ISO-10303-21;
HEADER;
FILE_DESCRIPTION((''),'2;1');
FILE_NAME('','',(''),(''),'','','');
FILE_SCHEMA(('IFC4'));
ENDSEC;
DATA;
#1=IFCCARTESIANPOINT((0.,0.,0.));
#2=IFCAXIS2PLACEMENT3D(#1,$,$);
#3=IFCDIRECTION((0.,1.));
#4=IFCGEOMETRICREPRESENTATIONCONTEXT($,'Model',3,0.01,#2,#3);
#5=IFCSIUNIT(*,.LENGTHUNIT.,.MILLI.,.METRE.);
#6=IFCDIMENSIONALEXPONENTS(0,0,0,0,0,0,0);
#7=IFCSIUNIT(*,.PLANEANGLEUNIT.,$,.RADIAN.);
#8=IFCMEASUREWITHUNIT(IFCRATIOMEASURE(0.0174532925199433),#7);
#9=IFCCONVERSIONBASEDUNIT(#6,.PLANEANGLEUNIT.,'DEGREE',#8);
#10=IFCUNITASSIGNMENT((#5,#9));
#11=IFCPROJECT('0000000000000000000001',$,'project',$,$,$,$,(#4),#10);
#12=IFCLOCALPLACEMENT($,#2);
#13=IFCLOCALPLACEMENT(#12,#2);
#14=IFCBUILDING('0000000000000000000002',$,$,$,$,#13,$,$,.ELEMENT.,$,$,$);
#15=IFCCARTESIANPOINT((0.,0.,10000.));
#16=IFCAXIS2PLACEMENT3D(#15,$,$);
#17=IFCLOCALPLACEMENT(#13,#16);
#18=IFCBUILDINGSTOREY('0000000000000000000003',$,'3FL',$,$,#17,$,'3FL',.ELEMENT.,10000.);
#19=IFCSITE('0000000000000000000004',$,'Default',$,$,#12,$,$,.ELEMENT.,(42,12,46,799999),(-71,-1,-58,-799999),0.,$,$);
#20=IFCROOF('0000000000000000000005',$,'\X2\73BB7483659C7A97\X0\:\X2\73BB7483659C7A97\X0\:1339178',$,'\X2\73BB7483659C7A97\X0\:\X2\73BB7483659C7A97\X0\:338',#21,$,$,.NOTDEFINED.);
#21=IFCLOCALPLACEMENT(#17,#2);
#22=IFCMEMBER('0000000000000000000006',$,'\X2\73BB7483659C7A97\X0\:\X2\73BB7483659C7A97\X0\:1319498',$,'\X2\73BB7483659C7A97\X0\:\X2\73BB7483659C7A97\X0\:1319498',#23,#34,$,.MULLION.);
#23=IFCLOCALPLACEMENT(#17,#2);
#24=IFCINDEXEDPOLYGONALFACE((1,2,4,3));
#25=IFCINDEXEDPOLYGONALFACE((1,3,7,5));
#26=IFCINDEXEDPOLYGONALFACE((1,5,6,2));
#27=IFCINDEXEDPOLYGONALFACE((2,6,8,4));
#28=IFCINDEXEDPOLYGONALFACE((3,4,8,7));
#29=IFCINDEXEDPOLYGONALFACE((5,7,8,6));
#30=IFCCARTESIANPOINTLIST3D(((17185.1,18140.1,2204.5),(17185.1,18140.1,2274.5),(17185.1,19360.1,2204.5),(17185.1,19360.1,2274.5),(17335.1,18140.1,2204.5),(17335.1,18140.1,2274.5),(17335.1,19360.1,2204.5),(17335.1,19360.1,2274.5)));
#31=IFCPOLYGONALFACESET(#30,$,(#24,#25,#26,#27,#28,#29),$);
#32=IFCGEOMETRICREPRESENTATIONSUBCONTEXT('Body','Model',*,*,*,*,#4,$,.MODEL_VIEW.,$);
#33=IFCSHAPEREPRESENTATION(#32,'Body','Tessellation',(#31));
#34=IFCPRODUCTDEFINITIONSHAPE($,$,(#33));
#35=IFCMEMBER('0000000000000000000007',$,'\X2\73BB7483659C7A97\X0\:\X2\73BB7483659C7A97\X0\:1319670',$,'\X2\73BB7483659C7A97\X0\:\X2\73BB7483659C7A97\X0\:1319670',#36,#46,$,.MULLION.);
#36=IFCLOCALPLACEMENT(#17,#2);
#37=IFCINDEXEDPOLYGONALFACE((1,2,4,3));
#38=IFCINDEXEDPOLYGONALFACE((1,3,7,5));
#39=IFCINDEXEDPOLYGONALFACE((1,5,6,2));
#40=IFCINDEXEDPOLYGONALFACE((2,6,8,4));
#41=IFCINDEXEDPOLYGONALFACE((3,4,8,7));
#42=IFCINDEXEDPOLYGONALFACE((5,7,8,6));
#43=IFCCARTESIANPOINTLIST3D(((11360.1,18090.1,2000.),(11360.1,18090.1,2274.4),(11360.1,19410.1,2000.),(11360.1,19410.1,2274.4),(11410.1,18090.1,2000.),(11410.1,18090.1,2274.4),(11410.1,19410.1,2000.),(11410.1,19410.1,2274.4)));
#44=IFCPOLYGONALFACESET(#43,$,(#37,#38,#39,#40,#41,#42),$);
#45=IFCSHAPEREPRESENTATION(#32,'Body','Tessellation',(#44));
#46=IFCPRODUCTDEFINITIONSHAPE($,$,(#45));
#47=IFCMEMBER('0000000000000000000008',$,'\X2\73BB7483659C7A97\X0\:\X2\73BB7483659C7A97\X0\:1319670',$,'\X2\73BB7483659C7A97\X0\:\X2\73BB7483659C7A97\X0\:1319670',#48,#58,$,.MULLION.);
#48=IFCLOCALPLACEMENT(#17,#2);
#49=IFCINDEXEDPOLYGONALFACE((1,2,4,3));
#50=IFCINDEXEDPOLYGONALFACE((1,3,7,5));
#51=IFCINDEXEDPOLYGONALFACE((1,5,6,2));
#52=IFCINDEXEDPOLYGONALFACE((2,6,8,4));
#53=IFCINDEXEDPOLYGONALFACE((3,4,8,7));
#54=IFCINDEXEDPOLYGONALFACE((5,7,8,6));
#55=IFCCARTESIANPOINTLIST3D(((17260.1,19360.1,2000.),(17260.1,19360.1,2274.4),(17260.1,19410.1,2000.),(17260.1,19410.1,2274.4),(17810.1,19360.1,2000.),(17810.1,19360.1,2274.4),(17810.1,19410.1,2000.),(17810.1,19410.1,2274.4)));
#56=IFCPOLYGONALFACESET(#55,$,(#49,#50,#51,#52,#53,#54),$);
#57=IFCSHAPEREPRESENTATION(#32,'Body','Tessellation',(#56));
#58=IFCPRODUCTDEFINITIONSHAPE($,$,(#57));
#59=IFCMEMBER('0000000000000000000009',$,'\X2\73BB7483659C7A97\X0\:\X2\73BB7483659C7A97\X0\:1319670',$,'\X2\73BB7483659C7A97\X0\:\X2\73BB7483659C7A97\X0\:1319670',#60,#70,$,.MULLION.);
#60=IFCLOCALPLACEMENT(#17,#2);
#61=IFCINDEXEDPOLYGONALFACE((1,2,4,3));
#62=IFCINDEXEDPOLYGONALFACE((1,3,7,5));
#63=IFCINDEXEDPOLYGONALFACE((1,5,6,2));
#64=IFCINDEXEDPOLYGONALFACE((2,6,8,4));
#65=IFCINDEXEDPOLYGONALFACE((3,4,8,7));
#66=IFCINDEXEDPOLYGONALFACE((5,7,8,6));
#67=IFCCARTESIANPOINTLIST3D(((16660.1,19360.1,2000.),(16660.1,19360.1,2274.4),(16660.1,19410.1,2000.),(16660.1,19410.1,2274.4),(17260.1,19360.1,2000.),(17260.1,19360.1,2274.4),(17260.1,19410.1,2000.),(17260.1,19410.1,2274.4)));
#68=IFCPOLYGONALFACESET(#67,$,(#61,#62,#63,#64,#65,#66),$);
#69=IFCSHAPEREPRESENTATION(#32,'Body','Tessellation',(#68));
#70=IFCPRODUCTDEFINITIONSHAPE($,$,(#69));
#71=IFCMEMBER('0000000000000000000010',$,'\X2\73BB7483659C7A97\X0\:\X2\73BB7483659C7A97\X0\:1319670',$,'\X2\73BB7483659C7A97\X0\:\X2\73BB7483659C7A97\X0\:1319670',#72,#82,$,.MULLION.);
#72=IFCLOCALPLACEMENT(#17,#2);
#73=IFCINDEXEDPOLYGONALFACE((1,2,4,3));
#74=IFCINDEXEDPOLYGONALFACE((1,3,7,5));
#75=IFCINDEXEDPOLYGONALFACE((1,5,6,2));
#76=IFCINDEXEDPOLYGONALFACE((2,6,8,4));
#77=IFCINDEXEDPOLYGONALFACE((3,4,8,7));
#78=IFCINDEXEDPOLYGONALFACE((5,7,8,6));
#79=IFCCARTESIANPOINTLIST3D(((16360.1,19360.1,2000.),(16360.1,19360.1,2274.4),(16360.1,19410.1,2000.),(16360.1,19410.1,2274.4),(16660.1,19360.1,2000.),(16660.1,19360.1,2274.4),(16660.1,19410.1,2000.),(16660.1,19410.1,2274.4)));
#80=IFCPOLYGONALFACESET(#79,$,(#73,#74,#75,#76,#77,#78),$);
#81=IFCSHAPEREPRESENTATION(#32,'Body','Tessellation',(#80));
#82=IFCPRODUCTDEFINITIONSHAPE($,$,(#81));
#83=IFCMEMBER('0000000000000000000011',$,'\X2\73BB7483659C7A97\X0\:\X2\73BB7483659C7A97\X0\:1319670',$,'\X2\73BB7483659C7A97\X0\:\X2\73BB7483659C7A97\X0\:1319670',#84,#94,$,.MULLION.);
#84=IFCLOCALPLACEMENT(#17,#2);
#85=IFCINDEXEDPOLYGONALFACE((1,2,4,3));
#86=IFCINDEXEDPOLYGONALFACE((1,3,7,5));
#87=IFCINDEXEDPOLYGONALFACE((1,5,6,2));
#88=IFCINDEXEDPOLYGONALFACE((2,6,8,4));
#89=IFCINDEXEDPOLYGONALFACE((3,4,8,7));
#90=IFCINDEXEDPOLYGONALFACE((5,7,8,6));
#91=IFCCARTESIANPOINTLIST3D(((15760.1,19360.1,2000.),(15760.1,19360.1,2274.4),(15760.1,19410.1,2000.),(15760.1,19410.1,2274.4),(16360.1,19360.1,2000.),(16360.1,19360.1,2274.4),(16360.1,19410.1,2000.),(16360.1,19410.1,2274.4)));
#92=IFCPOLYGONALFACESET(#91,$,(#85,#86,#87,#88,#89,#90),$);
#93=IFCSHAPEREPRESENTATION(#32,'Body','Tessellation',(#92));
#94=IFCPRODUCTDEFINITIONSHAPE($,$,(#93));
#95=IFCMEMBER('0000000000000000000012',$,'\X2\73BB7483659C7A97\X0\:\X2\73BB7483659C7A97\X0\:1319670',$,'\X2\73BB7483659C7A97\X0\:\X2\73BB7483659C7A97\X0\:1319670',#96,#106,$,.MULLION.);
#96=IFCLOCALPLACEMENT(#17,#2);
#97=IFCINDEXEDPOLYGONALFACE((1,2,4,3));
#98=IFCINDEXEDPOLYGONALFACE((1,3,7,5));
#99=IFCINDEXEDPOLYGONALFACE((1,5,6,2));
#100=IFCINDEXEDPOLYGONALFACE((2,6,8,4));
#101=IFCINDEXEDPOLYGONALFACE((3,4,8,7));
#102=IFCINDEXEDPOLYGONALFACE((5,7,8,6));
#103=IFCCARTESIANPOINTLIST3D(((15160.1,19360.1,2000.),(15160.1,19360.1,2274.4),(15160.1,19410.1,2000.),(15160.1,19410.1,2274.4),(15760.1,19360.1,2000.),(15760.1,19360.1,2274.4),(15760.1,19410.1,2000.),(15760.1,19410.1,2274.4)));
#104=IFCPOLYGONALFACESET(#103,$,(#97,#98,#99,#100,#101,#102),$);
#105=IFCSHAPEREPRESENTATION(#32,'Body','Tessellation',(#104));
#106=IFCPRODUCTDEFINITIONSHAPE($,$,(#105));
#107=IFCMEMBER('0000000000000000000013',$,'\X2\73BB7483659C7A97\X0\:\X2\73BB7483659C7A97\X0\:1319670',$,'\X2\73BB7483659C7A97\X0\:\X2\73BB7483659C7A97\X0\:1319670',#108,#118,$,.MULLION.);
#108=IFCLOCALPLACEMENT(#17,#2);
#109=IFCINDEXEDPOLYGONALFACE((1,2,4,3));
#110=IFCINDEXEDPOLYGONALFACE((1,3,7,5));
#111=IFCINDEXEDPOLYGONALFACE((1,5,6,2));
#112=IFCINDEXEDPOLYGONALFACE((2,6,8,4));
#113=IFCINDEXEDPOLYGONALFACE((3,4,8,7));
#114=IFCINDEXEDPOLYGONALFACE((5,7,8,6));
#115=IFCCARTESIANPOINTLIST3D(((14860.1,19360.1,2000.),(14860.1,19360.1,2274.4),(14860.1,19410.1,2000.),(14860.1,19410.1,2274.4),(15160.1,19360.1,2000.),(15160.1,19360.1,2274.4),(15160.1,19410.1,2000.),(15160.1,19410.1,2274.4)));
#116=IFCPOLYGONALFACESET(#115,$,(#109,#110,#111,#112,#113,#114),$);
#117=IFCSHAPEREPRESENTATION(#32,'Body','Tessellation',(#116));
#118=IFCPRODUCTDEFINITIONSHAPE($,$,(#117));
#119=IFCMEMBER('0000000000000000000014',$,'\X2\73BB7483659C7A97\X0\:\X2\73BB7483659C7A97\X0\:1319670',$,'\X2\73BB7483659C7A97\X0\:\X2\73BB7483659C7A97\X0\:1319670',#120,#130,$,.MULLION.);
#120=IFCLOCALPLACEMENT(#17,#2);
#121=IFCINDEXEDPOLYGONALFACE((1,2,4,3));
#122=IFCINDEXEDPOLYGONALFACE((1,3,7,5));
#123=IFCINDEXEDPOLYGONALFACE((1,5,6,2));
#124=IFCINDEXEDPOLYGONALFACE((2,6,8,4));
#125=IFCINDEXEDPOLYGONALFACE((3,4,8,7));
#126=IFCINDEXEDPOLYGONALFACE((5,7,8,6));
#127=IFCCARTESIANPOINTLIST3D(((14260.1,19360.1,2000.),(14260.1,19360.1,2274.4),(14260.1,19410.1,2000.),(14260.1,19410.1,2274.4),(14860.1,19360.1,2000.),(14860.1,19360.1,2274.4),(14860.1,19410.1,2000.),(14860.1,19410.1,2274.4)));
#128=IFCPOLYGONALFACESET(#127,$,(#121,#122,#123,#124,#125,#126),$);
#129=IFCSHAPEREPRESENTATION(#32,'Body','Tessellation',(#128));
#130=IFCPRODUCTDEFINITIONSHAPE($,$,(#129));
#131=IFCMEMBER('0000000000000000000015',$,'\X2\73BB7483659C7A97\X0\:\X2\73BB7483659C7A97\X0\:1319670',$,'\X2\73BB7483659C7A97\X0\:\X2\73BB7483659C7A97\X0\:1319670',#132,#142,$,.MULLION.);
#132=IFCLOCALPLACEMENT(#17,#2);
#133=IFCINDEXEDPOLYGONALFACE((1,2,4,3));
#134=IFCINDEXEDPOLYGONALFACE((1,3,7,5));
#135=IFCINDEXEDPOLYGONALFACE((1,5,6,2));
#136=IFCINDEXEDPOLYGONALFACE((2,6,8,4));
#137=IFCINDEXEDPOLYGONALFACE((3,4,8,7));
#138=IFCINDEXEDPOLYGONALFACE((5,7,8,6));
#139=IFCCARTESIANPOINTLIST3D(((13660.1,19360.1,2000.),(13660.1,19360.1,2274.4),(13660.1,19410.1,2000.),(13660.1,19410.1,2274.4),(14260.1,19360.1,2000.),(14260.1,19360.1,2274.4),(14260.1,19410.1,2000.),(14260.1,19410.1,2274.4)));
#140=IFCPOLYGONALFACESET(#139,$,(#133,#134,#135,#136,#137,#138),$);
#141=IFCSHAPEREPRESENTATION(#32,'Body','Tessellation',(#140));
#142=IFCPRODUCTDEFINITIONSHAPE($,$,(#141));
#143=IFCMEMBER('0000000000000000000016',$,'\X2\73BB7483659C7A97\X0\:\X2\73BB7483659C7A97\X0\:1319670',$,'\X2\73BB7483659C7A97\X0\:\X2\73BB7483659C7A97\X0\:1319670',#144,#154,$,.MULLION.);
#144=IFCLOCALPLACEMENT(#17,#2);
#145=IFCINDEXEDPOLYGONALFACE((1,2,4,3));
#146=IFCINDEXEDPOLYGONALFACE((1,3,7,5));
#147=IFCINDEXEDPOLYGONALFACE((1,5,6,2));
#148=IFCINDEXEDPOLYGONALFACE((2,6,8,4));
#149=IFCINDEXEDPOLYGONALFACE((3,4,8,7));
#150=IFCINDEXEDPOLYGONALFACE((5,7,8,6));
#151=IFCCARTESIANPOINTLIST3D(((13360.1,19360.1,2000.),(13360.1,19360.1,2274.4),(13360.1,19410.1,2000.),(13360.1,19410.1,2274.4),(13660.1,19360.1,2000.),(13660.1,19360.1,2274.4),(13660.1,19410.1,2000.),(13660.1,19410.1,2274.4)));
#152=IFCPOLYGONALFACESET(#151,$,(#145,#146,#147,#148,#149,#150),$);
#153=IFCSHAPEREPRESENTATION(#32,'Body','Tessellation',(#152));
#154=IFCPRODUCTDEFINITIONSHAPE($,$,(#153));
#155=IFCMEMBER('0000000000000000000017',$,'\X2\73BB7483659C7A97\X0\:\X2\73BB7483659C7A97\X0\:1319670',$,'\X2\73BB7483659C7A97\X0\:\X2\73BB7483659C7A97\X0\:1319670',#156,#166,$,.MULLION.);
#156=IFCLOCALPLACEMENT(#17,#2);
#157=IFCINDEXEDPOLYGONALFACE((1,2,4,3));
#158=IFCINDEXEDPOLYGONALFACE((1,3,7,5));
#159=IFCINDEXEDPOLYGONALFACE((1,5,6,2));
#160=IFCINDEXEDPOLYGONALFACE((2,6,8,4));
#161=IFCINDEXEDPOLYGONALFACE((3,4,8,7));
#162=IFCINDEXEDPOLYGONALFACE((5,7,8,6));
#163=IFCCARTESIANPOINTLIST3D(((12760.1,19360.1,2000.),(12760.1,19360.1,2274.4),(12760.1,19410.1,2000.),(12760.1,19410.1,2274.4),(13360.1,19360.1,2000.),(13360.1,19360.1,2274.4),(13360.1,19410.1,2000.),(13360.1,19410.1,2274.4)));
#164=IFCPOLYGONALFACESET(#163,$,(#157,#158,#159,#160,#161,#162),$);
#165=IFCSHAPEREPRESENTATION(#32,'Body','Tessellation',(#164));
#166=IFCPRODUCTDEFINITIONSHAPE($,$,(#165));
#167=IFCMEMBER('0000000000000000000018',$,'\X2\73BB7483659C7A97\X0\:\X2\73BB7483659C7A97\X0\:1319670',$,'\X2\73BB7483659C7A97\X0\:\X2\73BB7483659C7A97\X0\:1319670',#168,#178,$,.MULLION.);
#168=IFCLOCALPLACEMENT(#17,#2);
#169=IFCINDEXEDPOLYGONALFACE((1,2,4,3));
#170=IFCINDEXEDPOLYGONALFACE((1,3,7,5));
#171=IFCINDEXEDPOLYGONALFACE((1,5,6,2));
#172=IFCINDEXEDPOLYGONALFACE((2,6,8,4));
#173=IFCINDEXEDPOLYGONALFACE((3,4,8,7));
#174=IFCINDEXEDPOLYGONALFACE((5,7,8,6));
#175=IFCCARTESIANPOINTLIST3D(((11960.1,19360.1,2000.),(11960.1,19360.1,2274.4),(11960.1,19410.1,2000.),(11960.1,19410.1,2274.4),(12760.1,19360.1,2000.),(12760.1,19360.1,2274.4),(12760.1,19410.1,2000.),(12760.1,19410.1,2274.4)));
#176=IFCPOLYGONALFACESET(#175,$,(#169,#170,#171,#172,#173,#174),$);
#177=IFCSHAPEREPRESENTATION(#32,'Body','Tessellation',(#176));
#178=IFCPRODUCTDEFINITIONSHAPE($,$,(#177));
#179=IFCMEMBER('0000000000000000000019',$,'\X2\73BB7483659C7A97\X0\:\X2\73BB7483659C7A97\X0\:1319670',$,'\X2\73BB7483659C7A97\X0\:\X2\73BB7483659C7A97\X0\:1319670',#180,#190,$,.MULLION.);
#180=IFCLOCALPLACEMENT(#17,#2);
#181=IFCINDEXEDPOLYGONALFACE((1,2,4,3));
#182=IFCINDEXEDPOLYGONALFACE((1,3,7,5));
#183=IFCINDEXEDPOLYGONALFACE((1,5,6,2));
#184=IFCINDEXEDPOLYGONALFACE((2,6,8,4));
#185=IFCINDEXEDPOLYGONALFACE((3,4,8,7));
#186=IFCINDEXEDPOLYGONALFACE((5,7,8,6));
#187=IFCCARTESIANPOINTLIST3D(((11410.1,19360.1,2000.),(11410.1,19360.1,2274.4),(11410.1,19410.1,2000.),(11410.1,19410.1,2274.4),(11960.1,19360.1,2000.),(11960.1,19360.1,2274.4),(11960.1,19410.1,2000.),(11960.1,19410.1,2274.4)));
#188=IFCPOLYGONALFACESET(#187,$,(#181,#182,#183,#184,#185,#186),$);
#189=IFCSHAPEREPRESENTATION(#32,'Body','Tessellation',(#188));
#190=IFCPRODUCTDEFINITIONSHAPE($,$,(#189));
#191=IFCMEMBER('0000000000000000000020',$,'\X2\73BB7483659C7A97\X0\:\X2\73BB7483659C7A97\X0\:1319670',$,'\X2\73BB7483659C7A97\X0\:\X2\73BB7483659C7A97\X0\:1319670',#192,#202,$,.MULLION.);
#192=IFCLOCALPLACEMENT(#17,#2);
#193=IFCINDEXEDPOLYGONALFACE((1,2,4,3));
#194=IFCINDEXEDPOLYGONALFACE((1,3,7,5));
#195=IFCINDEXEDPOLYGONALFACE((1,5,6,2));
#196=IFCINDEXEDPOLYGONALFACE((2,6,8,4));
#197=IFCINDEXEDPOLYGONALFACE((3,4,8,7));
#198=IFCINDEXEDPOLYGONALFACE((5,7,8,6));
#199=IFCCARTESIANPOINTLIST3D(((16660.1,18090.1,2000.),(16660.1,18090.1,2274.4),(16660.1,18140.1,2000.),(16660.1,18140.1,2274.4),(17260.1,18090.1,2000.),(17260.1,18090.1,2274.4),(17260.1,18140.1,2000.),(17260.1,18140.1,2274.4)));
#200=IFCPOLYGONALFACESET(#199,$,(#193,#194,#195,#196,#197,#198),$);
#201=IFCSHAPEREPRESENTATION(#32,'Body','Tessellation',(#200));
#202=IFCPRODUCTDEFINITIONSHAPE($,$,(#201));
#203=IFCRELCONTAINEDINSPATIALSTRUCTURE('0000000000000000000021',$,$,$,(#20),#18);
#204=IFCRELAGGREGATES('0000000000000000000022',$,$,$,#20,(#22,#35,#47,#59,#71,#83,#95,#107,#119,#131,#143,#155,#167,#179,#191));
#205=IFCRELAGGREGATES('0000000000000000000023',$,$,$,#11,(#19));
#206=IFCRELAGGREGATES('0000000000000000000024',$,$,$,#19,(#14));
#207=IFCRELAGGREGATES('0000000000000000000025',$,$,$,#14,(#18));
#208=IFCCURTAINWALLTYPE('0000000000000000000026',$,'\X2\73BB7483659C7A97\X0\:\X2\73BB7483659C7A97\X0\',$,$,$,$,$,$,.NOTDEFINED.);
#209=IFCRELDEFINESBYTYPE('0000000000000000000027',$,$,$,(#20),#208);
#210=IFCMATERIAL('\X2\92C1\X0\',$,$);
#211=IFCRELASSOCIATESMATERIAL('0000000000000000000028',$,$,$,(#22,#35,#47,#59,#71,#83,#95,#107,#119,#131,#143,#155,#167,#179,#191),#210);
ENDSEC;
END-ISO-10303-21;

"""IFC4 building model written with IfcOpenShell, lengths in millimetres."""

from ifc_helpers import new_model, entity, si_unit, converted_unit, direction, frame, frame_2d, origin, place, context, subcontext, project, spatial, rectangle, extrude, material, type_object, element, aggregate, save


model = new_model("IFC4")

# Units and contexts
model_context = context("Model", 3, precision=0.01, world=origin(), true_north=direction((0.0, 1.0)))
body_context = subcontext(model_context, "Body", "Model", "MODEL_VIEW")
ifc_project = project(units=[si_unit("LENGTHUNIT", "METRE", prefix="MILLI"), converted_unit("PLANEANGLEUNIT", "DEGREE", entity("IfcRatioMeasure", 0.0174532925199433), si_unit("PLANEANGLEUNIT", "RADIAN"), dimensions=[0, 0, 0, 0, 0, 0, 0])], contexts=[model_context])

# Site, building, storey
site_placement = place(None, origin())
site = spatial("IfcSite", under=ifc_project, at=site_placement, Name="Default", CompositionType="ELEMENT", RefLatitude=(42, 12, 46, 799999), RefLongitude=(-71, -1, -58, -799999), RefElevation=0.0)
building_placement = place(site_placement, origin())
building = spatial("IfcBuilding", under=site, at=building_placement, CompositionType="ELEMENT")
storey_placement = place(building_placement, frame((0.0, 0.0, 10000.0)))
storey = spatial("IfcBuildingStorey", under=building, at=storey_placement, Name="3FL", LongName="3FL", CompositionType="ELEMENT", Elevation=10000.0)

# Roof, members
curtain_wall_type = type_object("IfcCurtainWallType", Name="玻璃斜窗:玻璃斜窗", PredefinedType="NOTDEFINED")
roof_placement = place(storey_placement, frame((0.0, 0.0, -10000.0)))
roof = element("IfcRoof", 1, at=roof_placement, inside=storey, type_object=curtain_wall_type, Name="玻璃斜窗:玻璃斜窗:1339178", ObjectType="玻璃斜窗:玻璃斜窗:338", PredefinedType="NOTDEFINED")
ifc_material = material(Name="鋁")
member_1_placement = place(roof_placement, frame((0.0, 0.0, 10000.0)))
member_1 = element("IfcMember", 2, at=member_1_placement, material=ifc_material, Name="玻璃斜窗:玻璃斜窗:1319498", ObjectType="玻璃斜窗:玻璃斜窗:1319498", PredefinedType="MULLION", context=body_context, shape_type="SweptSolid", body=[
    extrude(rectangle(XDim=70.0, YDim=150.0, at=frame_2d((0.0, 0.0), x_axis=(1.0, 0.0))), frame((17260.1, 18140.1, 2239.5), z_axis=(0.0, 1.0, 0.0), x_axis=(0.0, 0.0, -1.0)), (0.0, 0.0, 1.0), 1220.0),
])
member_2_placement = place(roof_placement, frame((0.0, 0.0, 10000.0)))
member_2 = element("IfcMember", 3, at=member_2_placement, material=ifc_material, Name="玻璃斜窗:玻璃斜窗:1319670", ObjectType="玻璃斜窗:玻璃斜窗:1319670", PredefinedType="MULLION", context=body_context, shape_type="SweptSolid", body=[
    extrude(rectangle(XDim=274.5, YDim=50.0, at=frame_2d((0.0, 0.0), x_axis=(1.0, 0.0))), frame((11385.1, 18090.1, 2137.2), z_axis=(0.0, 1.0, 0.0), x_axis=(0.0, 0.0, -1.0)), (0.0, 0.0, 1.0), 1320.0),
])
member_3_placement = place(roof_placement, frame((0.0, 0.0, 10000.0)))
member_3 = element("IfcMember", 4, at=member_3_placement, material=ifc_material, Name="玻璃斜窗:玻璃斜窗:1319670", ObjectType="玻璃斜窗:玻璃斜窗:1319670", PredefinedType="MULLION", context=body_context, shape_type="SweptSolid", body=[
    extrude(rectangle(XDim=274.5, YDim=50.0, at=frame_2d((0.0, 0.0), x_axis=(1.0, 0.0))), frame((17260.1, 19385.1, 2137.2), z_axis=(1.0, 0.0, 0.0), x_axis=(0.0, 0.0, -1.0)), (0.0, 0.0, 1.0), 550.0),
])
member_4_placement = place(roof_placement, frame((0.0, 0.0, 10000.0)))
member_4 = element("IfcMember", 5, at=member_4_placement, material=ifc_material, Name="玻璃斜窗:玻璃斜窗:1319670", ObjectType="玻璃斜窗:玻璃斜窗:1319670", PredefinedType="MULLION", context=body_context, shape_type="SweptSolid", body=[
    extrude(rectangle(XDim=274.5, YDim=50.0, at=frame_2d((0.0, 0.0), x_axis=(1.0, 0.0))), frame((16660.1, 19385.1, 2137.2), z_axis=(1.0, 0.0, 0.0), x_axis=(0.0, 0.0, -1.0)), (0.0, 0.0, 1.0), 600.0),
])
member_5_placement = place(roof_placement, frame((0.0, 0.0, 10000.0)))
member_5 = element("IfcMember", 6, at=member_5_placement, material=ifc_material, Name="玻璃斜窗:玻璃斜窗:1319670", ObjectType="玻璃斜窗:玻璃斜窗:1319670", PredefinedType="MULLION", context=body_context, shape_type="SweptSolid", body=[
    extrude(rectangle(XDim=274.5, YDim=50.0, at=frame_2d((0.0, 0.0), x_axis=(1.0, 0.0))), frame((16360.1, 19385.1, 2137.2), z_axis=(1.0, 0.0, 0.0), x_axis=(0.0, 0.0, -1.0)), (0.0, 0.0, 1.0), 300.0),
])
member_6_placement = place(roof_placement, frame((0.0, 0.0, 10000.0)))
member_6 = element("IfcMember", 7, at=member_6_placement, material=ifc_material, Name="玻璃斜窗:玻璃斜窗:1319670", ObjectType="玻璃斜窗:玻璃斜窗:1319670", PredefinedType="MULLION", context=body_context, shape_type="SweptSolid", body=[
    extrude(rectangle(XDim=274.5, YDim=50.0, at=frame_2d((0.0, 0.0), x_axis=(1.0, 0.0))), frame((15760.1, 19385.1, 2137.2), z_axis=(1.0, 0.0, 0.0), x_axis=(0.0, 0.0, -1.0)), (0.0, 0.0, 1.0), 600.0),
])
member_7_placement = place(roof_placement, frame((0.0, 0.0, 10000.0)))
member_7 = element("IfcMember", 8, at=member_7_placement, material=ifc_material, Name="玻璃斜窗:玻璃斜窗:1319670", ObjectType="玻璃斜窗:玻璃斜窗:1319670", PredefinedType="MULLION", context=body_context, shape_type="SweptSolid", body=[
    extrude(rectangle(XDim=274.5, YDim=50.0, at=frame_2d((0.0, 0.0), x_axis=(1.0, 0.0))), frame((15160.1, 19385.1, 2137.2), z_axis=(1.0, 0.0, 0.0), x_axis=(0.0, 0.0, -1.0)), (0.0, 0.0, 1.0), 600.0),
])
member_8_placement = place(roof_placement, frame((0.0, 0.0, 10000.0)))
member_8 = element("IfcMember", 9, at=member_8_placement, material=ifc_material, Name="玻璃斜窗:玻璃斜窗:1319670", ObjectType="玻璃斜窗:玻璃斜窗:1319670", PredefinedType="MULLION", context=body_context, shape_type="SweptSolid", body=[
    extrude(rectangle(XDim=274.5, YDim=50.0, at=frame_2d((0.0, 0.0), x_axis=(1.0, 0.0))), frame((14860.1, 19385.1, 2137.2), z_axis=(1.0, 0.0, 0.0), x_axis=(0.0, 0.0, -1.0)), (0.0, 0.0, 1.0), 300.0),
])
member_9_placement = place(roof_placement, frame((0.0, 0.0, 10000.0)))
member_9 = element("IfcMember", 10, at=member_9_placement, material=ifc_material, Name="玻璃斜窗:玻璃斜窗:1319670", ObjectType="玻璃斜窗:玻璃斜窗:1319670", PredefinedType="MULLION", context=body_context, shape_type="SweptSolid", body=[
    extrude(rectangle(XDim=274.5, YDim=50.0, at=frame_2d((0.0, 0.0), x_axis=(1.0, 0.0))), frame((14260.1, 19385.1, 2137.2), z_axis=(1.0, 0.0, 0.0), x_axis=(0.0, 0.0, -1.0)), (0.0, 0.0, 1.0), 600.0),
])
member_10_placement = place(roof_placement, frame((0.0, 0.0, 10000.0)))
member_10 = element("IfcMember", 11, at=member_10_placement, material=ifc_material, Name="玻璃斜窗:玻璃斜窗:1319670", ObjectType="玻璃斜窗:玻璃斜窗:1319670", PredefinedType="MULLION", context=body_context, shape_type="SweptSolid", body=[
    extrude(rectangle(XDim=274.5, YDim=50.0, at=frame_2d((0.0, 0.0), x_axis=(1.0, 0.0))), frame((13660.1, 19385.1, 2137.2), z_axis=(1.0, 0.0, 0.0), x_axis=(0.0, 0.0, -1.0)), (0.0, 0.0, 1.0), 600.0),
])
member_11_placement = place(roof_placement, frame((0.0, 0.0, 10000.0)))
member_11 = element("IfcMember", 12, at=member_11_placement, material=ifc_material, Name="玻璃斜窗:玻璃斜窗:1319670", ObjectType="玻璃斜窗:玻璃斜窗:1319670", PredefinedType="MULLION", context=body_context, shape_type="SweptSolid", body=[
    extrude(rectangle(XDim=274.5, YDim=50.0, at=frame_2d((0.0, 0.0), x_axis=(1.0, 0.0))), frame((13360.1, 19385.1, 2137.2), z_axis=(1.0, 0.0, 0.0), x_axis=(0.0, 0.0, -1.0)), (0.0, 0.0, 1.0), 300.0),
])
member_12_placement = place(roof_placement, frame((0.0, 0.0, 10000.0)))
member_12 = element("IfcMember", 13, at=member_12_placement, material=ifc_material, Name="玻璃斜窗:玻璃斜窗:1319670", ObjectType="玻璃斜窗:玻璃斜窗:1319670", PredefinedType="MULLION", context=body_context, shape_type="SweptSolid", body=[
    extrude(rectangle(XDim=274.5, YDim=50.0, at=frame_2d((0.0, 0.0), x_axis=(1.0, 0.0))), frame((12760.1, 19385.1, 2137.2), z_axis=(1.0, 0.0, 0.0), x_axis=(0.0, 0.0, -1.0)), (0.0, 0.0, 1.0), 600.0),
])
member_13_placement = place(roof_placement, frame((0.0, 0.0, 10000.0)))
member_13 = element("IfcMember", 14, at=member_13_placement, material=ifc_material, Name="玻璃斜窗:玻璃斜窗:1319670", ObjectType="玻璃斜窗:玻璃斜窗:1319670", PredefinedType="MULLION", context=body_context, shape_type="SweptSolid", body=[
    extrude(rectangle(XDim=274.5, YDim=50.0, at=frame_2d((0.0, 0.0), x_axis=(1.0, 0.0))), frame((11960.1, 19385.1, 2137.2), z_axis=(1.0, 0.0, 0.0), x_axis=(0.0, 0.0, -1.0)), (0.0, 0.0, 1.0), 800.0),
])
member_14_placement = place(roof_placement, frame((0.0, 0.0, 10000.0)))
member_14 = element("IfcMember", 15, at=member_14_placement, material=ifc_material, Name="玻璃斜窗:玻璃斜窗:1319670", ObjectType="玻璃斜窗:玻璃斜窗:1319670", PredefinedType="MULLION", context=body_context, shape_type="SweptSolid", body=[
    extrude(rectangle(XDim=274.5, YDim=50.0, at=frame_2d((0.0, 0.0), x_axis=(1.0, 0.0))), frame((11410.1, 19385.1, 2137.2), z_axis=(1.0, 0.0, 0.0), x_axis=(0.0, 0.0, -1.0)), (0.0, 0.0, 1.0), 550.0),
])
member_15_placement = place(roof_placement, frame((0.0, 0.0, 10000.0)))
member_15 = element("IfcMember", 16, at=member_15_placement, material=ifc_material, Name="玻璃斜窗:玻璃斜窗:1319670", ObjectType="玻璃斜窗:玻璃斜窗:1319670", PredefinedType="MULLION", context=body_context, shape_type="SweptSolid", body=[
    extrude(rectangle(XDim=274.5, YDim=50.0, at=frame_2d((0.0, 0.0), x_axis=(1.0, 0.0))), frame((17260.1, 18115.1, 2137.2), z_axis=(-1.0, 0.0, 0.0), x_axis=(0.0, 0.0, -1.0)), (0.0, 0.0, 1.0), 600.0),
])
aggregate(roof, [member_1, member_2, member_3, member_4, member_5, member_6, member_7, member_8, member_9, member_10, member_11, member_12, member_13, member_14, member_15])

save(model, "model.ifc")
